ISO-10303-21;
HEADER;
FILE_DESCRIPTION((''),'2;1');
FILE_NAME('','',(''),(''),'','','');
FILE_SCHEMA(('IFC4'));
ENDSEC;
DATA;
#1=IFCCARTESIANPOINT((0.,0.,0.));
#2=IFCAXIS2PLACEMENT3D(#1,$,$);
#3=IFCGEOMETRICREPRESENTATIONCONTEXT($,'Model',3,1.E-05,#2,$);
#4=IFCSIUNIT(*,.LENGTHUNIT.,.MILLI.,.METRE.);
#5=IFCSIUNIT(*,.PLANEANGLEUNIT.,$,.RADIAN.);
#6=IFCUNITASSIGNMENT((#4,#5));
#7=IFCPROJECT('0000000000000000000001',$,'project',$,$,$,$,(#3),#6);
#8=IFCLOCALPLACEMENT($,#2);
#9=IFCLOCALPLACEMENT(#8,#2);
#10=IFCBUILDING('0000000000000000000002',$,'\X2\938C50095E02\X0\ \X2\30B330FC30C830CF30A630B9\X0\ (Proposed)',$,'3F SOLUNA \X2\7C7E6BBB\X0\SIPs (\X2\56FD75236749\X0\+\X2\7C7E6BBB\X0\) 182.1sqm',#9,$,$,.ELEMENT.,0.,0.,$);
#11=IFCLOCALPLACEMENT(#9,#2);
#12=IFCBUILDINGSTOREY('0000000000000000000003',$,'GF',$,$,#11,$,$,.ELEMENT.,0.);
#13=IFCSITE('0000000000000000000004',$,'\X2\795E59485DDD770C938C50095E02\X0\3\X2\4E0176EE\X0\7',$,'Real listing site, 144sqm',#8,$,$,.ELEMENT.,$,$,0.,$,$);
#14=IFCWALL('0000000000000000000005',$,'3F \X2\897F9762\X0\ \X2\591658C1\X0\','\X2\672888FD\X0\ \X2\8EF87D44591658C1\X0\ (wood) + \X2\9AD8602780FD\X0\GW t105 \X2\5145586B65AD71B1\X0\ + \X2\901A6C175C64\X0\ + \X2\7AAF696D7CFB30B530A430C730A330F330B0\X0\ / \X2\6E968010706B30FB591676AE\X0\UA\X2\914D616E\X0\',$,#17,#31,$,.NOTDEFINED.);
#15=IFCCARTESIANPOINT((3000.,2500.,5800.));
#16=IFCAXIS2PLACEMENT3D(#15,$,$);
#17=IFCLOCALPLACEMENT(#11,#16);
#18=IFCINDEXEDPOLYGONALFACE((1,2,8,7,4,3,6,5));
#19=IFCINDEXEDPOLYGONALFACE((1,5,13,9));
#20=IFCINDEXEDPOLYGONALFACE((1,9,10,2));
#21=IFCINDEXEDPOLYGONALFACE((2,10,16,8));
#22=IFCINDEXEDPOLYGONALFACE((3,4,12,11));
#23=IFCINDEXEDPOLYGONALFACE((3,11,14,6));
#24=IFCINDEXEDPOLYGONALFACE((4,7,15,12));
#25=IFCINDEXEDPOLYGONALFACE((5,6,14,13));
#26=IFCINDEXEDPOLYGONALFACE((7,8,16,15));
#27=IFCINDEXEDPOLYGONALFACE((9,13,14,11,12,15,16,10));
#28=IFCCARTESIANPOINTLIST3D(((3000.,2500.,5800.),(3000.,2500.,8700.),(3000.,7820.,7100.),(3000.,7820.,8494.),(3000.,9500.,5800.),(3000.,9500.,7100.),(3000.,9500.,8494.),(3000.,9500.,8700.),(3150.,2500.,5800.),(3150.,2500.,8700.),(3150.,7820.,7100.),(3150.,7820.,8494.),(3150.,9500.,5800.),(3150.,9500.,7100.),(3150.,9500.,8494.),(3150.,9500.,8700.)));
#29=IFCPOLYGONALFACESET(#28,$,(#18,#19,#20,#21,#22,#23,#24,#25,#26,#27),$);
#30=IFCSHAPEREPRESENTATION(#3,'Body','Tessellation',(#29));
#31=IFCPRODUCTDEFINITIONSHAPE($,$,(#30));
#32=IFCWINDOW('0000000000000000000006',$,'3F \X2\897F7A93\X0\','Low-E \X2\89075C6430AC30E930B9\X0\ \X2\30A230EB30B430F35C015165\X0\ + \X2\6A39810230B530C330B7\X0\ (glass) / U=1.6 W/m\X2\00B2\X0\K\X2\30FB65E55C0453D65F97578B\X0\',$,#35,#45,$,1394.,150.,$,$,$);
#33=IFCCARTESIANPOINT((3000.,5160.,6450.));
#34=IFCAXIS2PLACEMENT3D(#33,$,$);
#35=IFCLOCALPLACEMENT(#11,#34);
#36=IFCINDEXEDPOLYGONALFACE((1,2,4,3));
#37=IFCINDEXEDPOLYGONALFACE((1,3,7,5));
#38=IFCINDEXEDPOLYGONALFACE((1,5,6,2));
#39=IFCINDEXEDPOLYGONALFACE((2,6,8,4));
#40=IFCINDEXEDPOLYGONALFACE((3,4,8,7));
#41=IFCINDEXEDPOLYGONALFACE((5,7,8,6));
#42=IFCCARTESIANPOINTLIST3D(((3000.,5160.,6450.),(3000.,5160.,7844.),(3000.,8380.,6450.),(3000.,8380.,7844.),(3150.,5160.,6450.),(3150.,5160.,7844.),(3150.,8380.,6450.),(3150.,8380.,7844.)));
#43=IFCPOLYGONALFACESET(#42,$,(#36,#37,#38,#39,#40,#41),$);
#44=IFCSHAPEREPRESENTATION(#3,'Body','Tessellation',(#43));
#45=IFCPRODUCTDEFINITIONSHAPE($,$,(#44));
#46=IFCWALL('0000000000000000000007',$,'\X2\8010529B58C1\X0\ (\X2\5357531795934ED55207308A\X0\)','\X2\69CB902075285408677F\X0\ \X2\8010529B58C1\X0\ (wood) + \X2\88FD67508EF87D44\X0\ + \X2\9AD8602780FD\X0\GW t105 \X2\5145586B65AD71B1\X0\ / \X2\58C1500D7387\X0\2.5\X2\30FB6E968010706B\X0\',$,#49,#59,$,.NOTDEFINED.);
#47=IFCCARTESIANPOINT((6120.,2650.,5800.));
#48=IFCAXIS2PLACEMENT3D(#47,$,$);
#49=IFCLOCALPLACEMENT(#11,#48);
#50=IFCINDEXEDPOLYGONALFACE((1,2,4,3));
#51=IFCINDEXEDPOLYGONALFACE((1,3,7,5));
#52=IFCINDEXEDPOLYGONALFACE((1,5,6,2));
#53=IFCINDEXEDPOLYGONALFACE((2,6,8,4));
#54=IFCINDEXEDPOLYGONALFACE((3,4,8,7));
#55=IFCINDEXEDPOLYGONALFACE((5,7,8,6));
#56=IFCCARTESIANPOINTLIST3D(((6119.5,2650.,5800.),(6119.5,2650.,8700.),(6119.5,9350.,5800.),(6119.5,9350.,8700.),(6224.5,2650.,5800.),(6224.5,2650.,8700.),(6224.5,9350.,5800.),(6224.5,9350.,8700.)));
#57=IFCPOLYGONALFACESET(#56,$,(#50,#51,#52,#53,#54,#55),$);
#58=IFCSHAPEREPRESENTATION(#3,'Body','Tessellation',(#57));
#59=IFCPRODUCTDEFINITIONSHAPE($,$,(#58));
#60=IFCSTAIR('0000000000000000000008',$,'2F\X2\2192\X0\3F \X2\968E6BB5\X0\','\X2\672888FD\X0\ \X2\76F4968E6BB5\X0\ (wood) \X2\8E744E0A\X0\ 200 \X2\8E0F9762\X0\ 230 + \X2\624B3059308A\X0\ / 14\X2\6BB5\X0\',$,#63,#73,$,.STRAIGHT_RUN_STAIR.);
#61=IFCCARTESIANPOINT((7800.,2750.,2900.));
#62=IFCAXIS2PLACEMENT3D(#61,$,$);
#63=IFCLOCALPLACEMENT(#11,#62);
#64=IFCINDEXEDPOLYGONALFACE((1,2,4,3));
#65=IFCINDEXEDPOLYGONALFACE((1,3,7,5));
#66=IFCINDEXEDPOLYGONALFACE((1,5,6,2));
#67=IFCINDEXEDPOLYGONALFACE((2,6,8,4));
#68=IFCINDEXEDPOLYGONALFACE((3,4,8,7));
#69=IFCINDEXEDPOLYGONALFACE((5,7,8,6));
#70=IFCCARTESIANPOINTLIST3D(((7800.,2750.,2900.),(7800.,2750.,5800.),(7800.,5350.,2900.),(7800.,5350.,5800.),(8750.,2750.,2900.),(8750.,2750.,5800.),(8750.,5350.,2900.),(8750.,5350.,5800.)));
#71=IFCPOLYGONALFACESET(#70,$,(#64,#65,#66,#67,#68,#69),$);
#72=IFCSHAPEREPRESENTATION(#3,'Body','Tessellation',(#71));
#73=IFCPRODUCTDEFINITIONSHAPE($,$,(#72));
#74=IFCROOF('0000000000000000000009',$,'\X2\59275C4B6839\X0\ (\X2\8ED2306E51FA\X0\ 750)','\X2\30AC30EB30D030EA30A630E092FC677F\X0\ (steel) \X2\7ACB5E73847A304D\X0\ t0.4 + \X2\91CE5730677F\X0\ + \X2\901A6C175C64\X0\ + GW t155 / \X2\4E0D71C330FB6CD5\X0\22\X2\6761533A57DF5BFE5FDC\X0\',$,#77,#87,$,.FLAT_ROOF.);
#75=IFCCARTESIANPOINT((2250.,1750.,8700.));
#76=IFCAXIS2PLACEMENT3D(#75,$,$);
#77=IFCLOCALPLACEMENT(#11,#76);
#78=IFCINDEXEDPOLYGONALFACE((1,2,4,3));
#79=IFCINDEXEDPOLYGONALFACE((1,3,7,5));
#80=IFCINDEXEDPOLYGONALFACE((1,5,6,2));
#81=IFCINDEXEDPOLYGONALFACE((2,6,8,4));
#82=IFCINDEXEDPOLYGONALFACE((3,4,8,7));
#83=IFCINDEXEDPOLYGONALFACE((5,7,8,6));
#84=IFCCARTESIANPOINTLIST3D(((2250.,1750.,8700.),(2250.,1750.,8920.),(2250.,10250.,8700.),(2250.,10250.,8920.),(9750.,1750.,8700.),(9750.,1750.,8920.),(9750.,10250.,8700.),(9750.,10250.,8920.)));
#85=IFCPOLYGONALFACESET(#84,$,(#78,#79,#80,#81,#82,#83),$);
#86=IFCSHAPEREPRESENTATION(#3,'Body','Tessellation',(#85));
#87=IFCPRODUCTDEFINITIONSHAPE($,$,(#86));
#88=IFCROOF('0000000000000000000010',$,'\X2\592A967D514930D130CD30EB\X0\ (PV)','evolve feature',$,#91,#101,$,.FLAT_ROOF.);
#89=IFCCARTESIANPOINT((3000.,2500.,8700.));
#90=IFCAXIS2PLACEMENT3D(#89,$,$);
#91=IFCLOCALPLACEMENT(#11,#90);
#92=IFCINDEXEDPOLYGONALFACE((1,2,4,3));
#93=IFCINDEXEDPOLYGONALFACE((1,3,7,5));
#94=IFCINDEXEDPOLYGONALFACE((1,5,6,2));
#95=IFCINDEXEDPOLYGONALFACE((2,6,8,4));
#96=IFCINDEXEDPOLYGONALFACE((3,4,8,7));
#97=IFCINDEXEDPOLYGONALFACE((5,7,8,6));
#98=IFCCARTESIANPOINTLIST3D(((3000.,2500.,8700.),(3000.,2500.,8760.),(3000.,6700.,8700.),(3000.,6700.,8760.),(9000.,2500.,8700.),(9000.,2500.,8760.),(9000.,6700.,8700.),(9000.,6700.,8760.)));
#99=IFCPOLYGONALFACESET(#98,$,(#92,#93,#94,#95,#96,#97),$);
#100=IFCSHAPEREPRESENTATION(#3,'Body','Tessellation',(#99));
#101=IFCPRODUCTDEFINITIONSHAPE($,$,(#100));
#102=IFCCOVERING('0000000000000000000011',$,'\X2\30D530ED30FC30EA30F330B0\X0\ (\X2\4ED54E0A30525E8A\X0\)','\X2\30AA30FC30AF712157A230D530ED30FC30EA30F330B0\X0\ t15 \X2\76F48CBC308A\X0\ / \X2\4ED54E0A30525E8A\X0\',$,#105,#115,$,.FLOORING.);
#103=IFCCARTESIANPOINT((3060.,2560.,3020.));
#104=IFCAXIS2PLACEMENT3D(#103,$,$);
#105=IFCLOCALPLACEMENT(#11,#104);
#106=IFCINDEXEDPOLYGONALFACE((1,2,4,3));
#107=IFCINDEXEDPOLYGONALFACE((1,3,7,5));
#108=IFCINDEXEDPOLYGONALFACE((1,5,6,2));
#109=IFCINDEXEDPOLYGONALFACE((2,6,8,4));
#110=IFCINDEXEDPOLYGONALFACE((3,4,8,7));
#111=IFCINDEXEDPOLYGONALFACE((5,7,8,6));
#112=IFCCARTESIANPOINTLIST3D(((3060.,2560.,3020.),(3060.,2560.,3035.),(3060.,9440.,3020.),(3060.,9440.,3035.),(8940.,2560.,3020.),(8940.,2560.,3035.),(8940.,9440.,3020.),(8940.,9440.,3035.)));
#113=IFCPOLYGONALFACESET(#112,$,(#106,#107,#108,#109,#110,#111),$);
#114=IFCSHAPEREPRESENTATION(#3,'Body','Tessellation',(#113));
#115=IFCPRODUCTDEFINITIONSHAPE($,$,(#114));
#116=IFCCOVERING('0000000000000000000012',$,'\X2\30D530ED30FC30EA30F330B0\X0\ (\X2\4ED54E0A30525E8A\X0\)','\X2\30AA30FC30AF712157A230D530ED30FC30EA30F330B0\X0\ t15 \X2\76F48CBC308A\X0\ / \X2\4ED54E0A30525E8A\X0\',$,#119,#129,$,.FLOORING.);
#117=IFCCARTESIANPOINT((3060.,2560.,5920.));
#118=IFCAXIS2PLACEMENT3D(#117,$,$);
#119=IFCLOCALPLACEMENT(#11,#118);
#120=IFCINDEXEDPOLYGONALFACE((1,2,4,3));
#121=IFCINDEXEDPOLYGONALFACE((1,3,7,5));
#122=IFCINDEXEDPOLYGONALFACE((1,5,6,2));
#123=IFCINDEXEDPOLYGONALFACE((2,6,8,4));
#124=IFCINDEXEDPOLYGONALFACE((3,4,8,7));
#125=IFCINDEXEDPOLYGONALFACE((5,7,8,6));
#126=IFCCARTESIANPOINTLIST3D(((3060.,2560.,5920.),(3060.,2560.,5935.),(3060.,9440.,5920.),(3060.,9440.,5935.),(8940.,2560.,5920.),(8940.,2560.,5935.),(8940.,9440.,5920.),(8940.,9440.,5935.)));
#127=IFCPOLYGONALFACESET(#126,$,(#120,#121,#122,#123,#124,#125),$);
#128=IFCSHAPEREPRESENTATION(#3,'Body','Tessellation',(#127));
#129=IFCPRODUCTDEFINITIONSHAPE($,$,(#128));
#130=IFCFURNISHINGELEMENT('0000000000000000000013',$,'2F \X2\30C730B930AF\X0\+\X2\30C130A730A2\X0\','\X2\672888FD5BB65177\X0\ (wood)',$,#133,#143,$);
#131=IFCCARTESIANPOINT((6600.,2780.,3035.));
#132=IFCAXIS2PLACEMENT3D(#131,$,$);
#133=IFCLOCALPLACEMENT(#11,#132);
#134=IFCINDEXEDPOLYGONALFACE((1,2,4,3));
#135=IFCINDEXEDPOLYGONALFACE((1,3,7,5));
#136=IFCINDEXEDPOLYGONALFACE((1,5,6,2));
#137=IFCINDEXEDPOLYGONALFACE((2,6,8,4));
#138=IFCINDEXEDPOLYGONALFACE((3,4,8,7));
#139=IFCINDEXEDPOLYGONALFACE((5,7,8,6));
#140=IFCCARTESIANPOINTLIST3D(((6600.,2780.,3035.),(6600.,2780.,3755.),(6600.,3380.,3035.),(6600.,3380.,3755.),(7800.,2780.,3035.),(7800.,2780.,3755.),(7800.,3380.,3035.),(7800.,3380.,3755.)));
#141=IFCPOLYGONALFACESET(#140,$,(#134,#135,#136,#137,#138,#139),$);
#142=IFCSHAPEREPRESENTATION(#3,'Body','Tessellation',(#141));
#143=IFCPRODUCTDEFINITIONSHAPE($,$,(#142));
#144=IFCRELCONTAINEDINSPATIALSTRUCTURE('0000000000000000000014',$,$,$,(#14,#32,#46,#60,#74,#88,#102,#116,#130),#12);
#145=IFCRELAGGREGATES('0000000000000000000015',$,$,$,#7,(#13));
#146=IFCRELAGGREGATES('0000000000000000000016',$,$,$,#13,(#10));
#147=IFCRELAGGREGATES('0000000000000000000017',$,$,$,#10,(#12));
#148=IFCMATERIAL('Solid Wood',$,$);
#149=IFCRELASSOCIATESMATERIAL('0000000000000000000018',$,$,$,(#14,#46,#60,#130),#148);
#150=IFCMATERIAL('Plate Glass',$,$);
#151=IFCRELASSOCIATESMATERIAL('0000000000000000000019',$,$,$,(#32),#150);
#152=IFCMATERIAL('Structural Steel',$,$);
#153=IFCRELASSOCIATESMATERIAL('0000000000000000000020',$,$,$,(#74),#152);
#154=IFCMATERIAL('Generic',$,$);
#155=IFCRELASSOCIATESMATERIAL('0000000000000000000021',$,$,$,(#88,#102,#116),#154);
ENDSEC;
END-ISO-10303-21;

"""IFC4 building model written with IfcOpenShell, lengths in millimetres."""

from ifc_helpers import new_model, si_unit, frame, frame_2d, origin, place, context, project, spatial, rectangle, extrude, material, element, fill, save


model = new_model("IFC4")

# Units and contexts
model_context = context("Model", 3, precision=1e-05, world=origin())
ifc_project = project(units=[si_unit("LENGTHUNIT", "METRE", prefix="MILLI"), si_unit("PLANEANGLEUNIT", "RADIAN")], contexts=[model_context])

# Site, building, storey
site_placement = place(None, origin())
site = spatial("IfcSite", under=ifc_project, at=site_placement, Name="神奈川県鎌倉市3丁目7", ObjectType="Real listing site, 144sqm", CompositionType="ELEMENT", RefElevation=0.0)
building_placement = place(site_placement, origin())
building = spatial("IfcBuilding", under=site, at=building_placement, Name="鎌倉市 コートハウス (Proposed)", ObjectType="3F SOLUNA 籾殻SIPs (国産杉+籾殻) 182.1sqm", CompositionType="ELEMENT", ElevationOfRefHeight=0.0, ElevationOfTerrain=0.0)
storey_placement = place(building_placement, origin())
storey = spatial("IfcBuildingStorey", under=building, at=storey_placement, Name="GF", CompositionType="ELEMENT", Elevation=0.0)

# Shared definitions
ifc_material_1 = material(Name="Solid Wood")

# Shared definitions
ifc_material_2 = material(Name="Plate Glass")

# Shared definitions
ifc_material_3 = material(Name="Generic")

# Wall, opening, window
wall_1_placement = place(storey_placement, frame((3000.0, 2500.0, 5800.0)))
wall_1 = element("IfcWall", 1, at=wall_1_placement, inside=storey, material=ifc_material_1, Name="3F 西面 外壁", Description="木製 軸組外壁 (wood) + 高性能GW t105 充填断熱 + 通気層 + 窯業系サイディング / 準耐火・外皮UA配慮", PredefinedType="NOTDEFINED", context=model_context, shape_type="SweptSolid", body=[
    extrude(rectangle(XDim=150.0, YDim=7000.0, at=frame_2d((75.0, 3500.0))), frame((3000.0, 2500.0, 5800.0)), (0.0, 0.0, 1.0), 2900.0),
])
opening_1_placement = place(storey_placement, frame((3000.0, 5160.0, 6450.0)))
opening_1 = element("IfcOpeningElement", 2, at=opening_1_placement, cuts=wall_1, PredefinedType="NOTDEFINED", context=model_context, shape_type="SweptSolid", body=[
    extrude(rectangle(XDim=150.0, YDim=3220.0, at=frame_2d((75.0, 1610.0))), frame((3000.0, 5160.0, 6450.0)), (0.0, 0.0, 1.0), 1394.0),
])
window_1_placement = place(storey_placement, frame((3000.0, 5160.0, 6450.0)))
window_1 = element("IfcWindow", 3, at=window_1_placement, inside=storey, material=ifc_material_2, Name="3F 西窓", Description="Low-E 複層ガラス アルゴン封入 + 樹脂サッシ (glass) / U=1.6 W/m²K・日射取得型", OverallHeight=1394.0, OverallWidth=150.0, context=model_context, shape_type="SweptSolid", body=[
    extrude(rectangle(XDim=150.0, YDim=3220.0, at=frame_2d((75.0, 1610.0))), frame((3000.0, 5160.0, 6450.0)), (0.0, 0.0, 1.0), 1394.0),
])
fill(opening_1, window_1)

# Wall
wall_2_placement = place(storey_placement, frame((6120.0, 2650.0, 5800.0)))
element("IfcWall", 4, at=wall_2_placement, inside=storey, material=ifc_material_1, Name="耐力壁 (南北間仕切り)", Description="構造用合板 耐力壁 (wood) + 製材軸組 + 高性能GW t105 充填断熱 / 壁倍率2.5・準耐火", PredefinedType="NOTDEFINED", context=model_context, shape_type="SweptSolid", body=[
    extrude(rectangle(XDim=105.0, YDim=6700.0, at=frame_2d((52.0, 3350.0))), frame((6120.0, 2650.0, 5800.0)), (0.0, 0.0, 1.0), 2900.0),
])

# Stair
stair_placement = place(storey_placement, frame((7800.0, 2750.0, 2900.0)))
element("IfcStair", 5, at=stair_placement, inside=storey, material=ifc_material_1, Name="2F→3F 階段", Description="木製 直階段 (wood) 蹴上 200 踏面 230 + 手すり / 14段", PredefinedType="STRAIGHT_RUN_STAIR", context=model_context, shape_type="SweptSolid", body=[
    extrude(rectangle(XDim=950.0, YDim=2600.0, at=frame_2d((475.0, 1300.0))), frame((7800.0, 2750.0, 2900.0)), (0.0, 0.0, 1.0), 2900.0),
])

# Roofs
ifc_material_4 = material(Name="Structural Steel")
roof_1_placement = place(storey_placement, frame((2250.0, 1750.0, 8700.0)))
element("IfcRoof", 6, at=roof_1_placement, inside=storey, material=ifc_material_4, Name="大屋根 (軒の出 750)", Description="ガルバリウム鋼板 (steel) 立平葺き t0.4 + 野地板 + 通気層 + GW t155 / 不燃・法22条区域対応", PredefinedType="FLAT_ROOF", context=model_context, shape_type="SweptSolid", body=[
    extrude(rectangle(XDim=7500.0, YDim=8500.0, at=frame_2d((3750.0, 4250.0))), frame((2250.0, 1750.0, 8700.0)), (0.0, 0.0, 1.0), 220.0),
])
roof_2_placement = place(storey_placement, frame((3000.0, 2500.0, 8700.0)))
element("IfcRoof", 7, at=roof_2_placement, inside=storey, material=ifc_material_3, Name="太陽光パネル (PV)", Description="evolve feature", PredefinedType="FLAT_ROOF", context=model_context, shape_type="SweptSolid", body=[
    extrude(rectangle(XDim=6000.0, YDim=4200.0, at=frame_2d((3000.0, 2100.0))), frame((3000.0, 2500.0, 8700.0)), (0.0, 0.0, 1.0), 60.0),
])

# Coverings
covering_1_placement = place(storey_placement, frame((3060.0, 2560.0, 3020.0)))
element("IfcCovering", 8, at=covering_1_placement, inside=storey, material=ifc_material_3, Name="フローリング (仕上げ床)", Description="オーク無垢フローリング t15 直貼り / 仕上げ床", PredefinedType="FLOORING", context=model_context, shape_type="SweptSolid", body=[
    extrude(rectangle(XDim=5880.0, YDim=6880.0, at=frame_2d((2940.0, 3440.0))), frame((3060.0, 2560.0, 3020.0)), (0.0, 0.0, 1.0), 15.0),
])
covering_2_placement = place(storey_placement, frame((3060.0, 2560.0, 5920.0)))
element("IfcCovering", 9, at=covering_2_placement, inside=storey, material=ifc_material_3, Name="フローリング (仕上げ床)", Description="オーク無垢フローリング t15 直貼り / 仕上げ床", PredefinedType="FLOORING", context=model_context, shape_type="SweptSolid", body=[
    extrude(rectangle(XDim=5880.0, YDim=6880.0, at=frame_2d((2940.0, 3440.0))), frame((3060.0, 2560.0, 5920.0)), (0.0, 0.0, 1.0), 15.0),
])

# Furnishing element
furnishing_placement = place(storey_placement, frame((6600.0, 2780.0, 3035.0)))
element("IfcFurnishingElement", 10, at=furnishing_placement, inside=storey, material=ifc_material_1, Name="2F デスク+チェア", Description="木製家具 (wood)", context=model_context, shape_type="SweptSolid", body=[
    extrude(rectangle(XDim=1200.0, YDim=600.0, at=frame_2d((600.0, 300.0))), frame((6600.0, 2780.0, 3035.0)), (0.0, 0.0, 1.0), 720.0),
])

save(model, "model.ifc")
